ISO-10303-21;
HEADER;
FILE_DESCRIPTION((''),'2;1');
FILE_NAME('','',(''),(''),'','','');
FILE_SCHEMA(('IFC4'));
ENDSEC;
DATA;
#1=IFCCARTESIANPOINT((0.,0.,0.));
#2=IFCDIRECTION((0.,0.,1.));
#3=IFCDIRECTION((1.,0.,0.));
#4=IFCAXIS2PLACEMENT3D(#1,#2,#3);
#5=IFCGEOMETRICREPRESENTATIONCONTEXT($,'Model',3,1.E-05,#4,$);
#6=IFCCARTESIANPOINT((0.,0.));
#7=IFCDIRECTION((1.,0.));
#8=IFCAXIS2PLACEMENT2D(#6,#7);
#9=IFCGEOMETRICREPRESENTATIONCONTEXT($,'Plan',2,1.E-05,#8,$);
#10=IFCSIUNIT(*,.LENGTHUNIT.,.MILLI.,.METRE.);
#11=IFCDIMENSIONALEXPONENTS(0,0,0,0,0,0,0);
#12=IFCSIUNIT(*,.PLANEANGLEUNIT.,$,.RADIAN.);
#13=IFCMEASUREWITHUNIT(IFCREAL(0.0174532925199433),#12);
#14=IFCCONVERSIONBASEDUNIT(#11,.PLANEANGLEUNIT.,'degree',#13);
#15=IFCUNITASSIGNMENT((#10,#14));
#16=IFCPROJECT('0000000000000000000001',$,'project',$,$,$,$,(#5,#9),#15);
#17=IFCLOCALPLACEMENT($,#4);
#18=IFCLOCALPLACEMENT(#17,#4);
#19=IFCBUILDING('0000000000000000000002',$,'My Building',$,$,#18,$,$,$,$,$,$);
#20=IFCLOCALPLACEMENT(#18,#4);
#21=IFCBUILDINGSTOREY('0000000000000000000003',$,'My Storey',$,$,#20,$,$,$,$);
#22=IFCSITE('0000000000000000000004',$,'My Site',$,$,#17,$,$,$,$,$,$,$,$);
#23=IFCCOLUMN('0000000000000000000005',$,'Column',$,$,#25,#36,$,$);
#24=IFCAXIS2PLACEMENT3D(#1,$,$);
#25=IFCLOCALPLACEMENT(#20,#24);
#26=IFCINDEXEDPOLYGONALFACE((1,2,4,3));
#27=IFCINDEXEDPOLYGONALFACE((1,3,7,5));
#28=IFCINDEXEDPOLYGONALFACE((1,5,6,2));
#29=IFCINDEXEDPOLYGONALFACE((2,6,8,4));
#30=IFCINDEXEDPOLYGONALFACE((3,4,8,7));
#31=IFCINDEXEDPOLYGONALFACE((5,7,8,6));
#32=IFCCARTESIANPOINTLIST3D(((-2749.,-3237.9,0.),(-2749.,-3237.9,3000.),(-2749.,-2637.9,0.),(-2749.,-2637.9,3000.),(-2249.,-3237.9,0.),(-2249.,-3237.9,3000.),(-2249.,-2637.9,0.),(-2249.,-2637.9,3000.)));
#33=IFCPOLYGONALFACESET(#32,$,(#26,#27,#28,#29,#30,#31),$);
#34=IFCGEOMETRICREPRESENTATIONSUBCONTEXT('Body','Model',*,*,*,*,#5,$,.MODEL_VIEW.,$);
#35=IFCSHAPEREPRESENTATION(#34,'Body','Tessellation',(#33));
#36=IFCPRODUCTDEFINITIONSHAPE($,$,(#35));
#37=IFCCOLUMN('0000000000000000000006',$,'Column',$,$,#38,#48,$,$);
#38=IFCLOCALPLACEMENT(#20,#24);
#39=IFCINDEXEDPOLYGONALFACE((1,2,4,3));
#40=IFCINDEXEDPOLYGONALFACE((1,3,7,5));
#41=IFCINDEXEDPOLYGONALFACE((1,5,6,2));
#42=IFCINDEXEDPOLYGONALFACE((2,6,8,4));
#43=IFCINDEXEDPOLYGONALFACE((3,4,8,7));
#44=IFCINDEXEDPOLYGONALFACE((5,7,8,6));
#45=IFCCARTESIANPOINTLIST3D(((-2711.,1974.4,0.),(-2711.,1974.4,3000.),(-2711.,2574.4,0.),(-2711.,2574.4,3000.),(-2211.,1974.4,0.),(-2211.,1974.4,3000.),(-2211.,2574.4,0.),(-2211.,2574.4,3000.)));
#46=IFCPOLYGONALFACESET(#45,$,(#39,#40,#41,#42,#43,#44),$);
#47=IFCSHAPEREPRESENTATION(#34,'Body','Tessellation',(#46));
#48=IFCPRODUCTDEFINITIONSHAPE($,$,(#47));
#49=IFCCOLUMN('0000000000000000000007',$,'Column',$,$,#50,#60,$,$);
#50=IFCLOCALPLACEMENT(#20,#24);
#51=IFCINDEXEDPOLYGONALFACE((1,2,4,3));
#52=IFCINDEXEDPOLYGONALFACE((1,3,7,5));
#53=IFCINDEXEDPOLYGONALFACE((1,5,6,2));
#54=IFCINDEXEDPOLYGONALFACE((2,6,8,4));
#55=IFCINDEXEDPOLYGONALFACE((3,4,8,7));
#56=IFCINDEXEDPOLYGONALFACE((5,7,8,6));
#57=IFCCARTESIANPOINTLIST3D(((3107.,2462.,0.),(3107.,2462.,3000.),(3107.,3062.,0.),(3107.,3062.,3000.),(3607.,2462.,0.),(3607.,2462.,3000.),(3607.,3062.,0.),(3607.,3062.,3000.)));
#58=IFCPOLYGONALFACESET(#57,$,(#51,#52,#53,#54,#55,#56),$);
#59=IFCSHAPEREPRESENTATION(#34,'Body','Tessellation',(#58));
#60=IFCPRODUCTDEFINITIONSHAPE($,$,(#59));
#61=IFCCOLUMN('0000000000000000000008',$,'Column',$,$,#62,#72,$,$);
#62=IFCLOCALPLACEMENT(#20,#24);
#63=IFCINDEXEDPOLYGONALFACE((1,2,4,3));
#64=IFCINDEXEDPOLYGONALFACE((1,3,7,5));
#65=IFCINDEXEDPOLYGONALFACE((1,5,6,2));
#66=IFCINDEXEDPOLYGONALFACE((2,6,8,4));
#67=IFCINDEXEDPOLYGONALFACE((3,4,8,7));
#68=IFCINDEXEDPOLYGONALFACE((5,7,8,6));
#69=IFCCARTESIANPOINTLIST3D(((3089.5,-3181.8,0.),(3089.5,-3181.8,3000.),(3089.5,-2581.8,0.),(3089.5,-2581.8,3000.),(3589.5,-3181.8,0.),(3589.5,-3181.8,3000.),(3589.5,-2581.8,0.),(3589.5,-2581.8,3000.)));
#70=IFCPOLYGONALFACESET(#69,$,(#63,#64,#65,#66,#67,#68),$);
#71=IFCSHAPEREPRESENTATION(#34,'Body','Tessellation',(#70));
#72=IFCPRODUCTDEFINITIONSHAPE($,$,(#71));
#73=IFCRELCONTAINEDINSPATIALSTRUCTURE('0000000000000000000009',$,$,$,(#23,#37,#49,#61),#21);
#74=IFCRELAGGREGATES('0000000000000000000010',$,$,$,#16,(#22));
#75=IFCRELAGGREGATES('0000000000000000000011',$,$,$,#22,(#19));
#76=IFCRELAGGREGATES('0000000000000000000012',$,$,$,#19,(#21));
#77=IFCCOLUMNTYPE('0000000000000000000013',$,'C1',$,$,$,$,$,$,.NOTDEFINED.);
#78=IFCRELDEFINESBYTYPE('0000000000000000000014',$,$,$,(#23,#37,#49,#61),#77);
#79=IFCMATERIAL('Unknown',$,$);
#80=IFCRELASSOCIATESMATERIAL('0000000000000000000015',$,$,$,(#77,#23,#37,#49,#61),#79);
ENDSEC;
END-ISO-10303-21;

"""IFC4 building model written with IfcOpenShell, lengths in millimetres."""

from ifc_helpers import new_model, entity, si_unit, converted_unit, frame, origin_with_axes, origin_2d_with_axis, place, context, subcontext, project, spatial, rectangle, extrude, material, material_profile, profile_set, profile_usage, type_object, element, save


model = new_model("IFC4")

# Units and contexts
model_context = context("Model", 3, precision=1e-05, world=origin_with_axes())
plan_context = context("Plan", 2, precision=1e-05, world=origin_2d_with_axis())
body_context = subcontext(model_context, "Body", "Model", "MODEL_VIEW")
ifc_project = project(units=[si_unit("LENGTHUNIT", "METRE", prefix="MILLI"), converted_unit("PLANEANGLEUNIT", "degree", entity("IfcReal", 0.0174532925199433), si_unit("PLANEANGLEUNIT", "RADIAN"), dimensions=[0, 0, 0, 0, 0, 0, 0])], contexts=[model_context, plan_context])

# Site, building, storey
site_placement = place(None, origin_with_axes())
site = spatial("IfcSite", under=ifc_project, at=site_placement, Name="My Site")
building_placement = place(site_placement, origin_with_axes())
building = spatial("IfcBuilding", under=site, at=building_placement, Name="My Building")
storey_placement = place(building_placement, origin_with_axes())
storey = spatial("IfcBuildingStorey", under=building, at=storey_placement, Name="My Storey")

# Columns
ifc_material = material(Name="Unknown")
ifc_material_profile = material_profile(ifc_material, rectangle(XDim=500.0, YDim=600.0))
ifc_profile_set = profile_set([ifc_material_profile])
ifc_profile_usage_1 = profile_usage(ifc_profile_set, cardinal=5)
column_type = type_object("IfcColumnType", Name="C1", PredefinedType="NOTDEFINED", material=ifc_profile_set)
column_1_placement = place(storey_placement, frame((-2499.0, -2937.9, 0.0), z_axis=(0.0, 0.0, 1.0), x_axis=(1.0, 0.0, 0.0)))
element("IfcColumn", 1, at=column_1_placement, inside=storey, type_object=column_type, material=ifc_profile_usage_1, Name="Column", context=body_context, shape_type="SweptSolid", body=[
    extrude(rectangle(XDim=500.0, YDim=600.0), origin_with_axes(), (0.0, 0.0, 1.0), 3000.0),
])
ifc_profile_usage_2 = profile_usage(ifc_profile_set, cardinal=5)
column_2_placement = place(storey_placement, frame((-2461.0, 2274.4, 0.0), z_axis=(0.0, 0.0, 1.0), x_axis=(1.0, 0.0, 0.0)))
element("IfcColumn", 2, at=column_2_placement, inside=storey, type_object=column_type, material=ifc_profile_usage_2, Name="Column", context=body_context, shape_type="SweptSolid", body=[
    extrude(rectangle(XDim=500.0, YDim=600.0), origin_with_axes(), (0.0, 0.0, 1.0), 3000.0),
])
ifc_profile_usage_3 = profile_usage(ifc_profile_set, cardinal=5)
column_3_placement = place(storey_placement, frame((3357.0, 2762.0, 0.0), z_axis=(0.0, 0.0, 1.0), x_axis=(1.0, 0.0, 0.0)))
element("IfcColumn", 3, at=column_3_placement, inside=storey, type_object=column_type, material=ifc_profile_usage_3, Name="Column", context=body_context, shape_type="SweptSolid", body=[
    extrude(rectangle(XDim=500.0, YDim=600.0), origin_with_axes(), (0.0, 0.0, 1.0), 3000.0),
])
ifc_profile_usage_4 = profile_usage(ifc_profile_set, cardinal=5)
column_4_placement = place(storey_placement, frame((3339.5, -2881.8, 0.0), z_axis=(0.0, 0.0, 1.0), x_axis=(1.0, 0.0, 0.0)))
element("IfcColumn", 4, at=column_4_placement, inside=storey, type_object=column_type, material=ifc_profile_usage_4, Name="Column", context=body_context, shape_type="SweptSolid", body=[
    extrude(rectangle(XDim=500.0, YDim=600.0), origin_with_axes(), (0.0, 0.0, 1.0), 3000.0),
])

save(model, "model.ifc")
